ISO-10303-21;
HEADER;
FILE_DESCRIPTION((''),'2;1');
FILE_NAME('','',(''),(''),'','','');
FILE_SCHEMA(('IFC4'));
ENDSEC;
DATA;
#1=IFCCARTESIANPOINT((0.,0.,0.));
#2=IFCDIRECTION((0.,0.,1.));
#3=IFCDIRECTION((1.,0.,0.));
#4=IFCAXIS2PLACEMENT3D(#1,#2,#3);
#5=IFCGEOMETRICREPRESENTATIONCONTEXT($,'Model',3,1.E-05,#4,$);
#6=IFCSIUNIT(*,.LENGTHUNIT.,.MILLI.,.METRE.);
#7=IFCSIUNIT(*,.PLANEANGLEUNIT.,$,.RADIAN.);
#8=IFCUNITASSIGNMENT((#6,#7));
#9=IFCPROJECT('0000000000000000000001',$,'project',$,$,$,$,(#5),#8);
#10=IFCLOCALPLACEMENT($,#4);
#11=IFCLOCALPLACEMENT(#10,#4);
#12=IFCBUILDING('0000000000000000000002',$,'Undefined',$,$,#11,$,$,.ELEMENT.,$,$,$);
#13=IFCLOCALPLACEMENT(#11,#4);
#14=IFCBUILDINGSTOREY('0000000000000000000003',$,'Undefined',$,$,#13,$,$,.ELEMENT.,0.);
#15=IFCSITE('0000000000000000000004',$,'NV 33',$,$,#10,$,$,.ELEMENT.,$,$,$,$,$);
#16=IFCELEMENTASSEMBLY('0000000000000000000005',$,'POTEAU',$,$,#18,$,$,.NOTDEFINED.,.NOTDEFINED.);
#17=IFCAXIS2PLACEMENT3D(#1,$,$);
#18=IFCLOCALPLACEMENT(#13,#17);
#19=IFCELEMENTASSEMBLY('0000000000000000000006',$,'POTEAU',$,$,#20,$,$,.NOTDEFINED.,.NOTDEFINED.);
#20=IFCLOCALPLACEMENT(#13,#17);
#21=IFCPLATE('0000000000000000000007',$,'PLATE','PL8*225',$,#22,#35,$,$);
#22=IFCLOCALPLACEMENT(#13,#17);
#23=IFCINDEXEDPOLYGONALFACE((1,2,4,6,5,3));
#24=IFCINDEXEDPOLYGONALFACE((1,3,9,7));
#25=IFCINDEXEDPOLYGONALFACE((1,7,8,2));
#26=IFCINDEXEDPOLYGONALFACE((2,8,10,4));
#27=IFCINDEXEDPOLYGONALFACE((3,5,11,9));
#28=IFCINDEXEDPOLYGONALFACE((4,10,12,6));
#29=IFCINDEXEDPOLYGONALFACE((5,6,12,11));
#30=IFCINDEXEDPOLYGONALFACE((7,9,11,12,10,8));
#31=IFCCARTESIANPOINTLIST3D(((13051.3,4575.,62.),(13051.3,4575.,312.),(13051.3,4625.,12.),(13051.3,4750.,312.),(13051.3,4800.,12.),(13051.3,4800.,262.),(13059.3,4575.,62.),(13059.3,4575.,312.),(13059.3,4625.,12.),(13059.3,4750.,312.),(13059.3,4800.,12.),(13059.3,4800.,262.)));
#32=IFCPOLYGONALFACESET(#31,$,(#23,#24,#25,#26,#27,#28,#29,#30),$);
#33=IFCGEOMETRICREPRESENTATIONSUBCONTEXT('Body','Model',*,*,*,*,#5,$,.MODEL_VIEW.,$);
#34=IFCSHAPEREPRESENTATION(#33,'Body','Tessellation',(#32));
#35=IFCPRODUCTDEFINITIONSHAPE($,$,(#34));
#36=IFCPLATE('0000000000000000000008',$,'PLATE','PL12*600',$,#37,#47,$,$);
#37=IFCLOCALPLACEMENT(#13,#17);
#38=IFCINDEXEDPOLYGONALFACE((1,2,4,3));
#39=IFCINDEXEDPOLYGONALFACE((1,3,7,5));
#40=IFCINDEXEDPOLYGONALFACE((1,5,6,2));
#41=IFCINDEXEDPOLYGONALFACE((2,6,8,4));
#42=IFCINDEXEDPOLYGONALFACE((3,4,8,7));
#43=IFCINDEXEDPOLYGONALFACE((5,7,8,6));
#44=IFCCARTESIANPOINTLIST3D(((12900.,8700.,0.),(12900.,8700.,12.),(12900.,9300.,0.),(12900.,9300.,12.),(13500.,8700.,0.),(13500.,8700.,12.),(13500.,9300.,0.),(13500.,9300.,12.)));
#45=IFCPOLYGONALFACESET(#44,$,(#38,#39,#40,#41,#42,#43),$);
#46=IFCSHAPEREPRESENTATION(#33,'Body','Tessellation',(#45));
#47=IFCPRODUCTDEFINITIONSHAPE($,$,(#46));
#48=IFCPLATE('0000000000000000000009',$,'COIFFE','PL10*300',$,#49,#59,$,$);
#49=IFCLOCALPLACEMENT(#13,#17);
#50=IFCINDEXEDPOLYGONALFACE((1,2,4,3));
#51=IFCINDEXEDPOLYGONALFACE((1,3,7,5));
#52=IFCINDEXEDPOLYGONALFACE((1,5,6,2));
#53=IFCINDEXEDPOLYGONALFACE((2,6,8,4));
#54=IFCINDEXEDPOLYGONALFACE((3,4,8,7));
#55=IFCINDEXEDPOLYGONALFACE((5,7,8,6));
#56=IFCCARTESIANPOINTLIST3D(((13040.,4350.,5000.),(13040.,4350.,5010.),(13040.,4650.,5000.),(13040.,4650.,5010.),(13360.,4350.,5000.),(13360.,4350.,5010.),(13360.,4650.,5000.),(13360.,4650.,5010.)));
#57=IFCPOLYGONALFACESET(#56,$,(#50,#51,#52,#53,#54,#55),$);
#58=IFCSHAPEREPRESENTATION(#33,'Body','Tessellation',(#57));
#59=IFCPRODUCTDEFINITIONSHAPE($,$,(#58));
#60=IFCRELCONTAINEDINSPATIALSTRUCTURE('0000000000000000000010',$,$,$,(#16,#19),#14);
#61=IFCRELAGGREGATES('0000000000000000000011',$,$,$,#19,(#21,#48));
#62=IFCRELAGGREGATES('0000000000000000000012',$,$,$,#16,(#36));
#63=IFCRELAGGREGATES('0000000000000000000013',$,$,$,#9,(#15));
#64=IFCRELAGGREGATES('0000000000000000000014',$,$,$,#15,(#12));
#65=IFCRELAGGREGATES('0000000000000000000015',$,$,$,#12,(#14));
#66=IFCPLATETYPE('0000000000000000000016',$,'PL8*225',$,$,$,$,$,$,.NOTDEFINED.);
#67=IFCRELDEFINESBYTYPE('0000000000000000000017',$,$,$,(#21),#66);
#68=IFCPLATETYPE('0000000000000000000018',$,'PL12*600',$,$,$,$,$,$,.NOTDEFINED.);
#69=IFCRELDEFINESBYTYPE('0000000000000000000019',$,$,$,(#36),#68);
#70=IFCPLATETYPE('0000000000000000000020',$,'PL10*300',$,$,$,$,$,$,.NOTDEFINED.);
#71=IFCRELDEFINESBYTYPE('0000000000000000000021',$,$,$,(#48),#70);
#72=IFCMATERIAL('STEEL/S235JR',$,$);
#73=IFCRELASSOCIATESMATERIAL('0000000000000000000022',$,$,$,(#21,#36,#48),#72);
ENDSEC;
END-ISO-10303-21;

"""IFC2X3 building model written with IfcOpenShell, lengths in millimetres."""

from ifc_helpers import new_model, si_unit, frame, origin_with_axes, place, context, subcontext, project, spatial, polyline, outline, extrude, material, type_object, element, aggregate, save


model = new_model("IFC2X3")

# Units and contexts
model_context = context("Model", 3, precision=1e-05, world=origin_with_axes())
body_context = subcontext(model_context, "Body", "Model", "MODEL_VIEW")
ifc_project = project(units=[si_unit("LENGTHUNIT", "METRE", prefix="MILLI"), si_unit("PLANEANGLEUNIT", "RADIAN")], contexts=[model_context])

# Site, building, storey
site_placement = place(None, origin_with_axes())
site = spatial("IfcSite", under=ifc_project, at=site_placement, Name="NV 33", CompositionType="ELEMENT")
building_placement = place(site_placement, origin_with_axes())
building = spatial("IfcBuilding", under=site, at=building_placement, Name="Undefined", CompositionType="ELEMENT")
storey_placement = place(building_placement, origin_with_axes())
storey = spatial("IfcBuildingStorey", under=building, at=storey_placement, Name="Undefined", CompositionType="ELEMENT", Elevation=0.0)

# Element assemblies
assembly_1_placement = place(storey_placement, origin_with_axes())
assembly_1 = element("IfcElementAssembly", 1, at=assembly_1_placement, inside=storey, Name="POTEAU", AssemblyPlace="NOTDEFINED", PredefinedType="NOTDEFINED")
ifc_material_1 = material(Name="STEEL/S235JR")
assembly_2_placement = place(storey_placement, origin_with_axes())
assembly_2 = element("IfcElementAssembly", 2, at=assembly_2_placement, inside=storey, Name="POTEAU", AssemblyPlace="NOTDEFINED", PredefinedType="NOTDEFINED")

# Plates
plate_type_1 = type_object("IfcPlateType", Name="PL8*225", PredefinedType="NOTDEFINED")
plate_1_placement = place(assembly_2_placement, frame((13055.3, 4575.0, 12.0), z_axis=(1.0, 0.0, 0.0), x_axis=(0.0, 1.0, 0.0)))
plate_1 = element("IfcPlate", 3, at=plate_1_placement, type_object=plate_type_1, material=ifc_material_1, Name="PLATE", Description="PL8*225", context=body_context, shape_type="SweptSolid", body=[
    extrude(outline(polyline([(0.0, 50.0), (50.0, 0.0), (225.0, 0.0), (225.0, 250.0), (175.0, 300.0), (0.0, 300.0), (0.0, 50.0)])), frame((0.0, 0.0, -4.0), z_axis=(0.0, 0.0, 1.0), x_axis=(1.0, 0.0, 0.0)), (0.0, 0.0, 1.0), 8.0),
])
plate_type_2 = type_object("IfcPlateType", Name="PL12*600", PredefinedType="NOTDEFINED")
plate_2_placement = place(assembly_1_placement, frame((12900.0, 8700.0, 6.0), z_axis=(0.0, 0.0, 1.0), x_axis=(1.0, 0.0, 0.0)))
plate_2 = element("IfcPlate", 4, at=plate_2_placement, type_object=plate_type_2, material=ifc_material_1, Name="PLATE", Description="PL12*600", context=body_context, shape_type="SweptSolid", body=[
    extrude(outline(polyline([(0.0, 0.0), (600.0, 0.0), (600.0, 600.0), (0.0, 600.0), (0.0, 0.0)])), frame((0.0, 0.0, -6.0), z_axis=(0.0, 0.0, 1.0), x_axis=(1.0, 0.0, 0.0)), (0.0, 0.0, 1.0), 12.0),
])
plate_type_3 = type_object("IfcPlateType", Name="PL10*300", PredefinedType="NOTDEFINED")
plate_3_placement = place(assembly_2_placement, frame((13040.0, 4650.0, 5005.0), z_axis=(0.0, 0.0, 1.0), x_axis=(0.0, -1.0, 0.0)))
plate_3 = element("IfcPlate", 5, at=plate_3_placement, type_object=plate_type_3, material=ifc_material_1, Name="COIFFE", Description="PL10*300", context=body_context, shape_type="SweptSolid", body=[
    extrude(outline(polyline([(0.0, 0.0), (300.0, 0.0), (300.0, 320.0), (0.0, 320.0), (0.0, 0.0)])), frame((0.0, 0.0, -5.0), z_axis=(0.0, 0.0, 1.0), x_axis=(1.0, 0.0, 0.0)), (0.0, 0.0, 1.0), 10.0),
])
aggregate(assembly_2, [plate_1, plate_3])

aggregate(assembly_1, [plate_2])

save(model, "model.ifc")
